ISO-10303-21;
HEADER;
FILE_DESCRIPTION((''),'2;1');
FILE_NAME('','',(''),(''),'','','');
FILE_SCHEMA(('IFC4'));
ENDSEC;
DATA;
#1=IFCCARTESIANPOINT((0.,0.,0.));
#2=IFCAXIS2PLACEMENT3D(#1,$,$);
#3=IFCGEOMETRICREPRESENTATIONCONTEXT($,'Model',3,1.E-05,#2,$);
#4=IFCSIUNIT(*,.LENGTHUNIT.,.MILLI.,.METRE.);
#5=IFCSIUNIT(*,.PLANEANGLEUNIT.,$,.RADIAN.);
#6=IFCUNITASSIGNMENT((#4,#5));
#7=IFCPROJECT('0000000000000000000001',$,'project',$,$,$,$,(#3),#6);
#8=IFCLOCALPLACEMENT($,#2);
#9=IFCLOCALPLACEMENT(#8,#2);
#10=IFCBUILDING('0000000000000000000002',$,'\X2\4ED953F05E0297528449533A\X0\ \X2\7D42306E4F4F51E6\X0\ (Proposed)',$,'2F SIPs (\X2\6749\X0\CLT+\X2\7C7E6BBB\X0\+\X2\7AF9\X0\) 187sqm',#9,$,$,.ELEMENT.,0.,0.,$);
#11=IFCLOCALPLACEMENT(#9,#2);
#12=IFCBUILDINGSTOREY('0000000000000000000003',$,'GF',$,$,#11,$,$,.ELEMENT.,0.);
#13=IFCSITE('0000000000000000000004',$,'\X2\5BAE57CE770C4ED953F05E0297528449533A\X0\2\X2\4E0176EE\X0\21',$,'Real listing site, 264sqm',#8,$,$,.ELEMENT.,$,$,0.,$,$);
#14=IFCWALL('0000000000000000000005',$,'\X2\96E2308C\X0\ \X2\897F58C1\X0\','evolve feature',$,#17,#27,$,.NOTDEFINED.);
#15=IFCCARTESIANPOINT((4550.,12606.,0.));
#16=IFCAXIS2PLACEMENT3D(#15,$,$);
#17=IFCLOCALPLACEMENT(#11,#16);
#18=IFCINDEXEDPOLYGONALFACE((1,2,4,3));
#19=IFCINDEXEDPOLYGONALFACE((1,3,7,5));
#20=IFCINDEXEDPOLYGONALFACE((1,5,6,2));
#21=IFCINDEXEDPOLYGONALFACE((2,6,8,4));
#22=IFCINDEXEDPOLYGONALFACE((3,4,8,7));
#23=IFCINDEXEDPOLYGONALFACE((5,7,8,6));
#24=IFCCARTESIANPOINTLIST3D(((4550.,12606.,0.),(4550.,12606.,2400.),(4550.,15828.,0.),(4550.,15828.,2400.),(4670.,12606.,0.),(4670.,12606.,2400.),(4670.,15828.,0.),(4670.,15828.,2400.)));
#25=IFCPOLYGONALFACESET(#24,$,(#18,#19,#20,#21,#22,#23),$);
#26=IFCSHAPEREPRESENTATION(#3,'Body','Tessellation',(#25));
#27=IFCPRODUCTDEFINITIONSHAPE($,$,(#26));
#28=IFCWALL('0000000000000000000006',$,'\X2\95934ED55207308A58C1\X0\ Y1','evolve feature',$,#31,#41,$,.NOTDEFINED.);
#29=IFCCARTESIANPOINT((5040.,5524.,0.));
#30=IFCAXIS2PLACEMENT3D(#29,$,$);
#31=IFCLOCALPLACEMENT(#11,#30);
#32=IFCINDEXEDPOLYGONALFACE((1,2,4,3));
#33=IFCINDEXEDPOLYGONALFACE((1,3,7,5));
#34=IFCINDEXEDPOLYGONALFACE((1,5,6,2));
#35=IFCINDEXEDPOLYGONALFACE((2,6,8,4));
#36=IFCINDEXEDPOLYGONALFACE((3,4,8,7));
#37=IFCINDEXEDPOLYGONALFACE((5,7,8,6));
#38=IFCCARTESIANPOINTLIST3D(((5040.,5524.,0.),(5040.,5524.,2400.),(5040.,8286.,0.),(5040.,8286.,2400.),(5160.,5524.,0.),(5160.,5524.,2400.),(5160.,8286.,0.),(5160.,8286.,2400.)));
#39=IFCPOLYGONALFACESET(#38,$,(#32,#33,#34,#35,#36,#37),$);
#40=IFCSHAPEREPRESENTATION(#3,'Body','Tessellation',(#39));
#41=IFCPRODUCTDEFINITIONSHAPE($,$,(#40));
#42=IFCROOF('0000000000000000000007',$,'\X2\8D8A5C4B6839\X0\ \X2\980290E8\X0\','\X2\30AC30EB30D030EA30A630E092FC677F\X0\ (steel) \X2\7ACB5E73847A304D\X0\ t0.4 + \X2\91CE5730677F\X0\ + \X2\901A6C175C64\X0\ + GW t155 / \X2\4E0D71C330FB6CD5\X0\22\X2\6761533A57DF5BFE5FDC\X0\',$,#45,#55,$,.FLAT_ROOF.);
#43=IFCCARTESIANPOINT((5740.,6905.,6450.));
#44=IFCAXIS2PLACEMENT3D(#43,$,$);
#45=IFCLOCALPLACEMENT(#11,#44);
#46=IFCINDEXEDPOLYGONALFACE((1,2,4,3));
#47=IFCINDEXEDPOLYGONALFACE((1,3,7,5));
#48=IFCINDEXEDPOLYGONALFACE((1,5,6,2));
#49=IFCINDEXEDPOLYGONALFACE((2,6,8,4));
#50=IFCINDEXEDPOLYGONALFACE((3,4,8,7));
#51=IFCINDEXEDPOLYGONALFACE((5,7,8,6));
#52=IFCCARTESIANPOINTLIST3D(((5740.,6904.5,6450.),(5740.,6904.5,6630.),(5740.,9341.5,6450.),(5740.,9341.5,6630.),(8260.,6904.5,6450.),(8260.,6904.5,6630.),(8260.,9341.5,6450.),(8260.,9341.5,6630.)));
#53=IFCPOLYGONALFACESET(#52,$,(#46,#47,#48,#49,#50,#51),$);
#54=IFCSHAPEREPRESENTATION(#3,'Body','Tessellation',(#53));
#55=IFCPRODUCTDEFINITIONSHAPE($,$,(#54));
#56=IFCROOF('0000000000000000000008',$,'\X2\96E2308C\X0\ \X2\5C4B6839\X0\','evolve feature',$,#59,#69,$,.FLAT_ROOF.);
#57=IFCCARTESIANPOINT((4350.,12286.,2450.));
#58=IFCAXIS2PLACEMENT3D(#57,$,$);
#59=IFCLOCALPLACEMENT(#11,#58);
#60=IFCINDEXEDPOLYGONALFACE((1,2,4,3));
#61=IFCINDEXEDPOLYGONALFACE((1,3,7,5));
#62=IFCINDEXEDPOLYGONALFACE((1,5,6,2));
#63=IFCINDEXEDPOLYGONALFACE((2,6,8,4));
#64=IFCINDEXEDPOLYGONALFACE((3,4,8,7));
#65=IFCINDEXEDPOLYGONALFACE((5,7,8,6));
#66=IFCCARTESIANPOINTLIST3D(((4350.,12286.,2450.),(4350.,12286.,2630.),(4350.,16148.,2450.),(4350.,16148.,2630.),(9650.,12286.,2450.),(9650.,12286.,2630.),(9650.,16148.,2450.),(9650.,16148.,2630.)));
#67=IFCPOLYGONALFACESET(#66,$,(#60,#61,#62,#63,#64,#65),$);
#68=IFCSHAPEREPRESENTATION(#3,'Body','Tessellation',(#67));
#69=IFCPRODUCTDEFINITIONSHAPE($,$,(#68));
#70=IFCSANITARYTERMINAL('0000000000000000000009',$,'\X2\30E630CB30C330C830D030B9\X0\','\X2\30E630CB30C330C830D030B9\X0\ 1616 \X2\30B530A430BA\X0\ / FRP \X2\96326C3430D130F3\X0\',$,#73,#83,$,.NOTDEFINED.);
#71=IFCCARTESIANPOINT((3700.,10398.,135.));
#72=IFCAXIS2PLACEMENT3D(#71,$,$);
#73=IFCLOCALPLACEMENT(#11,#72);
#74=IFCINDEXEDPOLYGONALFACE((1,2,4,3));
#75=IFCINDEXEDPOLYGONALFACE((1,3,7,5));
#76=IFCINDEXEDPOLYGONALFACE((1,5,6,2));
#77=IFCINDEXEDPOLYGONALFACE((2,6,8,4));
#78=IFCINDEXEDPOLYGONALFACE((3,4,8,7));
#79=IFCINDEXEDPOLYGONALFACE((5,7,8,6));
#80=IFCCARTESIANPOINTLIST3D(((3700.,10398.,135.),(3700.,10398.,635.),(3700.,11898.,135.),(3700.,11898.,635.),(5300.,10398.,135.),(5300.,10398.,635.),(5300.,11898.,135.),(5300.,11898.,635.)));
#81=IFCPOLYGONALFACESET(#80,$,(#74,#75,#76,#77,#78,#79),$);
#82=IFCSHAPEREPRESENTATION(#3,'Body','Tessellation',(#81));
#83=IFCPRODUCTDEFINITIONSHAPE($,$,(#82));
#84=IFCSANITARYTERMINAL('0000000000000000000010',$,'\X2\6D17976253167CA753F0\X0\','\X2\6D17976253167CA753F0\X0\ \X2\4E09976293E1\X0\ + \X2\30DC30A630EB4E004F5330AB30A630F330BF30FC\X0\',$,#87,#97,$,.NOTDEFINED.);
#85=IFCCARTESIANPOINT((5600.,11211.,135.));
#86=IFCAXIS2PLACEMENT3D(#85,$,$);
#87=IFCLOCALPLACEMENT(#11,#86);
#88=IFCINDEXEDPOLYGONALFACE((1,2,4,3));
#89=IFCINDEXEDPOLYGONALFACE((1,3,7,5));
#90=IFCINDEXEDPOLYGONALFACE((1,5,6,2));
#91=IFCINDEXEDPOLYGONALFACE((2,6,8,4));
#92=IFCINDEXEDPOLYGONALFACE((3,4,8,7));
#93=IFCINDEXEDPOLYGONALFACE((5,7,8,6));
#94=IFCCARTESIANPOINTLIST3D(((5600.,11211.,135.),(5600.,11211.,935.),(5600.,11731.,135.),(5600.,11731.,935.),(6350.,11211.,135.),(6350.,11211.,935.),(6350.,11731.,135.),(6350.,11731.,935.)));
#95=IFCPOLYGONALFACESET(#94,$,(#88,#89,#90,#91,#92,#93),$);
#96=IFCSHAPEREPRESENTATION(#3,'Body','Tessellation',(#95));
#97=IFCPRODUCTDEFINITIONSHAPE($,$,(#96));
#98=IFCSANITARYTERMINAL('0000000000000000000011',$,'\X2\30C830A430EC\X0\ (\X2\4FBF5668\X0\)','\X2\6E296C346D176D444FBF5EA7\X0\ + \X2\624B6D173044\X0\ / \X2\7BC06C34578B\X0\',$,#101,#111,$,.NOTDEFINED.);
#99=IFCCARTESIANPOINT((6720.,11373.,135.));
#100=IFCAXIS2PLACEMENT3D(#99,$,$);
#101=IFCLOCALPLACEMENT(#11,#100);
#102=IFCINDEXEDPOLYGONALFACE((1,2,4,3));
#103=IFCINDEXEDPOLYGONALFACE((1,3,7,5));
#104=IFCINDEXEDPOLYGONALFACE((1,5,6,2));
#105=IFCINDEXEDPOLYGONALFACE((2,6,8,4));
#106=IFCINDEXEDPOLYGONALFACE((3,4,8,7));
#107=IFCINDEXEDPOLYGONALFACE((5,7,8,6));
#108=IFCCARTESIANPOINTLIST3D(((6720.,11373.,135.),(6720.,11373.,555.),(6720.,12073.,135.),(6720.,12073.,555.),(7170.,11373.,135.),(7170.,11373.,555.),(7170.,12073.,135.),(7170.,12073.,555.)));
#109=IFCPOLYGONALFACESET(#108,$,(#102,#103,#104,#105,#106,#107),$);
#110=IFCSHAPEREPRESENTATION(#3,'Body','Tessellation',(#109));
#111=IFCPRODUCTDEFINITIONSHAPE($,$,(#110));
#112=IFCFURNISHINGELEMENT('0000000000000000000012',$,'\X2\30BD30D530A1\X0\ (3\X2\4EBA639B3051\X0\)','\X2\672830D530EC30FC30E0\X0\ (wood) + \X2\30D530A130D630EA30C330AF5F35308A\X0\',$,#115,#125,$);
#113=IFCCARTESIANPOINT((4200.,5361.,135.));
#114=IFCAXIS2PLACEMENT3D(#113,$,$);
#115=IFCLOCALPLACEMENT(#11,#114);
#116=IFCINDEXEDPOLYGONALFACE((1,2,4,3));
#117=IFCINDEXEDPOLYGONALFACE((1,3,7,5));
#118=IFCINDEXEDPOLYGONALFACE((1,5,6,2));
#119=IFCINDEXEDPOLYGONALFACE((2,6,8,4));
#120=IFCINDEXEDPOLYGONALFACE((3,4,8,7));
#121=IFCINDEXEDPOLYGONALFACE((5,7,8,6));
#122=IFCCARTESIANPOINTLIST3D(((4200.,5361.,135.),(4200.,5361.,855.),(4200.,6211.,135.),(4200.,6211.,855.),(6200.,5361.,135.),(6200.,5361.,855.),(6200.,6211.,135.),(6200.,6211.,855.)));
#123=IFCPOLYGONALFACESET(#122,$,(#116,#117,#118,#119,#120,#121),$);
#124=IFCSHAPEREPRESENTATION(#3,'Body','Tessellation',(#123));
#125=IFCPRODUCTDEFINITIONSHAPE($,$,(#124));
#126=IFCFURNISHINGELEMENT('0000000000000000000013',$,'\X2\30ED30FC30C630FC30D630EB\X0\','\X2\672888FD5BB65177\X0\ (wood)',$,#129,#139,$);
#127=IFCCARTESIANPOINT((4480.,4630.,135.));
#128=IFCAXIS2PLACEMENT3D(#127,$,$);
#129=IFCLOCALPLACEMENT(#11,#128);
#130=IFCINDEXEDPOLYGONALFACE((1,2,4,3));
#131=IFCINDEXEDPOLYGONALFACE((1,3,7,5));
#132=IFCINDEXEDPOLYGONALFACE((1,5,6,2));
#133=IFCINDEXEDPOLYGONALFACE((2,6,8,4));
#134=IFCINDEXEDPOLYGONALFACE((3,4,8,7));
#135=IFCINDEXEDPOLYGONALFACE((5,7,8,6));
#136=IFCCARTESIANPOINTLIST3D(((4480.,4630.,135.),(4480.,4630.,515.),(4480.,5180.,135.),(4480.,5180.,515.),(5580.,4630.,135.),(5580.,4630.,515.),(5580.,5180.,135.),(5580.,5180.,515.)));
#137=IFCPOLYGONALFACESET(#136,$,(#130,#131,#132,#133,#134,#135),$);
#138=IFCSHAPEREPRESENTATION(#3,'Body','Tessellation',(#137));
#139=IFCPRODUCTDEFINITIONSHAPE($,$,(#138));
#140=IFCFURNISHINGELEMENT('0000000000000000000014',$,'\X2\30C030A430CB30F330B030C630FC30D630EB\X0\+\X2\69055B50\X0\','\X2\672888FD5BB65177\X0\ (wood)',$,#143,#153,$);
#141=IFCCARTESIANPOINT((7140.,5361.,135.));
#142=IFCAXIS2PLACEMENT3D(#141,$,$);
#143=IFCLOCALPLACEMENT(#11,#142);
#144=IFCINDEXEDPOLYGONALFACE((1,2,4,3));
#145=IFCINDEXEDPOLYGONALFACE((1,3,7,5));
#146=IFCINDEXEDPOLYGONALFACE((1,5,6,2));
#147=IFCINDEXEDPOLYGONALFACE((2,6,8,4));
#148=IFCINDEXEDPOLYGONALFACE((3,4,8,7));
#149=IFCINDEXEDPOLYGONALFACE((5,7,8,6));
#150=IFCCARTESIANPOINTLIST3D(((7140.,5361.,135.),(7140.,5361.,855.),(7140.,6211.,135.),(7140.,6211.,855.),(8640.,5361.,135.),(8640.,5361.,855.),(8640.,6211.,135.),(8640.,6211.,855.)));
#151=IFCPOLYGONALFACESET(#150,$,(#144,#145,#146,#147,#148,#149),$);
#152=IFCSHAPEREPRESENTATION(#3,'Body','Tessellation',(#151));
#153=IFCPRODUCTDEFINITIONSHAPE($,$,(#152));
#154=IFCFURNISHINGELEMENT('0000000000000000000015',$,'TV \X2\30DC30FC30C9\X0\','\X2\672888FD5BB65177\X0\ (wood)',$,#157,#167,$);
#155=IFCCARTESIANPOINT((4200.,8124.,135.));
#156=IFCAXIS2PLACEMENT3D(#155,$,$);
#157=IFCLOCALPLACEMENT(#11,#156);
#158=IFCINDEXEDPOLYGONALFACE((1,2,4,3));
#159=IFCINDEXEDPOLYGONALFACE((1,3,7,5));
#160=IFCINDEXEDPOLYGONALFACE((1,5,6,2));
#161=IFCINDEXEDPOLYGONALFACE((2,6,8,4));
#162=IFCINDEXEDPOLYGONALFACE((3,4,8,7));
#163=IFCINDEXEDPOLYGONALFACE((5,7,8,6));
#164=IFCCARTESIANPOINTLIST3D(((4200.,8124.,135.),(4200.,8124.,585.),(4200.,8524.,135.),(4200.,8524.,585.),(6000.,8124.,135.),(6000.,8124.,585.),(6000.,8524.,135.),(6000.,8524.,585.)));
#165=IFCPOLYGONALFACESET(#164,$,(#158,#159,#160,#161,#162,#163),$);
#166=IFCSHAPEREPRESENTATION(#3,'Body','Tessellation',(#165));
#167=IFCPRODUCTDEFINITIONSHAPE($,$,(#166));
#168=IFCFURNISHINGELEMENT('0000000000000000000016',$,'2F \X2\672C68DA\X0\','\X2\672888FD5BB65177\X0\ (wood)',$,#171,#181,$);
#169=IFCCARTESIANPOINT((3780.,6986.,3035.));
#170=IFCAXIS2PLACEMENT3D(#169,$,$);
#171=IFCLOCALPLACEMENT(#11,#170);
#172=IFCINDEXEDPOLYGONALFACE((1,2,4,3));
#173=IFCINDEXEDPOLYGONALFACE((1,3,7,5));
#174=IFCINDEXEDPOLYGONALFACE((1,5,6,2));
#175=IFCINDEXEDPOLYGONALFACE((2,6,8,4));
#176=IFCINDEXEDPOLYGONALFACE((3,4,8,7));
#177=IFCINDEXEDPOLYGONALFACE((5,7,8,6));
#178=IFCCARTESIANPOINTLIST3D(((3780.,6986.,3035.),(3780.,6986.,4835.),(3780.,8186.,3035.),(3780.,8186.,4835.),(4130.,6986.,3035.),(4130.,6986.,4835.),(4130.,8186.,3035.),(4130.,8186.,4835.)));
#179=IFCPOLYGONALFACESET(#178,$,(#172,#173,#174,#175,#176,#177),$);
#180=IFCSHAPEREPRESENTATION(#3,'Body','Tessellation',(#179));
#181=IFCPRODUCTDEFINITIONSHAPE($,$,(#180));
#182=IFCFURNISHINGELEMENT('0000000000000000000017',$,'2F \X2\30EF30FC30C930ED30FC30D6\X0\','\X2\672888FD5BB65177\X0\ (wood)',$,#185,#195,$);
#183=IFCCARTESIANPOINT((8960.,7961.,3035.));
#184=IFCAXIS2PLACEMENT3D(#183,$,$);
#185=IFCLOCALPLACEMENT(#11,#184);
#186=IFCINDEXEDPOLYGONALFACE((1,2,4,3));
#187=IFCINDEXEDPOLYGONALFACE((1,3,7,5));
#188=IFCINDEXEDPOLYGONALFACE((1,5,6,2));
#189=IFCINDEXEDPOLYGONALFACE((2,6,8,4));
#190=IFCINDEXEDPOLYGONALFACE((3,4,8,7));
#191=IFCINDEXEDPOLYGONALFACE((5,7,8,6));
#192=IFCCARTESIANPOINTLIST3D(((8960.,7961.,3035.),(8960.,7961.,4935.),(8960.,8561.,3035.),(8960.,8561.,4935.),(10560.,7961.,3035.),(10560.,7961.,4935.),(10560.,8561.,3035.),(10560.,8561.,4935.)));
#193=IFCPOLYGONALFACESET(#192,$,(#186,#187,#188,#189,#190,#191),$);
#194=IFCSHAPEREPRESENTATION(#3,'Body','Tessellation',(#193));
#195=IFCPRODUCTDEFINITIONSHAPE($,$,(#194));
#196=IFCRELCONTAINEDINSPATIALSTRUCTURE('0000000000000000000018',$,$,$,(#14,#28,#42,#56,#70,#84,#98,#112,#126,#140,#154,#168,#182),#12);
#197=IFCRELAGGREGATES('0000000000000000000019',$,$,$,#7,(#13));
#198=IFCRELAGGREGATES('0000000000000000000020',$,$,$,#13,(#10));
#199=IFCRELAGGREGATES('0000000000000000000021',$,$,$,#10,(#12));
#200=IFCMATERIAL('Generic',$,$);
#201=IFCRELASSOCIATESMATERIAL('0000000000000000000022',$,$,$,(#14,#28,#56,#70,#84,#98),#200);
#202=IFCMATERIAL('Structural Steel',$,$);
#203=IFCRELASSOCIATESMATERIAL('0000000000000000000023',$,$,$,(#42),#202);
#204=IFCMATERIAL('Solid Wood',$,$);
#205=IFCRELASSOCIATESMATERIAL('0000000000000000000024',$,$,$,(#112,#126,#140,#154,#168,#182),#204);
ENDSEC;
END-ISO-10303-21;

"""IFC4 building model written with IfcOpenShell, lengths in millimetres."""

from ifc_helpers import new_model, si_unit, frame, frame_2d, origin, place, context, project, spatial, rectangle, extrude, material, element, save


model = new_model("IFC4")

# Units and contexts
model_context = context("Model", 3, precision=1e-05, world=origin())
ifc_project = project(units=[si_unit("LENGTHUNIT", "METRE", prefix="MILLI"), si_unit("PLANEANGLEUNIT", "RADIAN")], contexts=[model_context])

# Site, building, storey
site_placement = place(None, origin())
site = spatial("IfcSite", under=ifc_project, at=site_placement, Name="宮城県仙台市青葉区2丁目21", ObjectType="Real listing site, 264sqm", CompositionType="ELEMENT", RefElevation=0.0)
building_placement = place(site_placement, origin())
building = spatial("IfcBuilding", under=site, at=building_placement, Name="仙台市青葉区 終の住処 (Proposed)", ObjectType="2F SIPs (杉CLT+籾殻+竹) 187sqm", CompositionType="ELEMENT", ElevationOfRefHeight=0.0, ElevationOfTerrain=0.0)
storey_placement = place(building_placement, origin())
storey = spatial("IfcBuildingStorey", under=building, at=storey_placement, Name="GF", CompositionType="ELEMENT", Elevation=0.0)

# Shared definitions
ifc_material_1 = material(Name="Generic")

# Shared definitions
ifc_material_2 = material(Name="Solid Wood")

# Walls
wall_1_placement = place(storey_placement, frame((4550.0, 12606.0, 0.0)))
element("IfcWall", 1, at=wall_1_placement, inside=storey, material=ifc_material_1, Name="離れ 西壁", Description="evolve feature", PredefinedType="NOTDEFINED", context=model_context, shape_type="SweptSolid", body=[
    extrude(rectangle(XDim=120.0, YDim=3222.0, at=frame_2d((60.0, 1611.0))), frame((4550.0, 12606.0, 0.0)), (0.0, 0.0, 1.0), 2400.0),
])
wall_2_placement = place(storey_placement, frame((5040.0, 5524.0, 0.0)))
element("IfcWall", 2, at=wall_2_placement, inside=storey, material=ifc_material_1, Name="間仕切り壁 Y1", Description="evolve feature", PredefinedType="NOTDEFINED", context=model_context, shape_type="SweptSolid", body=[
    extrude(rectangle(XDim=120.0, YDim=2762.0, at=frame_2d((60.0, 1381.0))), frame((5040.0, 5524.0, 0.0)), (0.0, 0.0, 1.0), 2400.0),
])

# Roofs
ifc_material_3 = material(Name="Structural Steel")
roof_1_placement = place(storey_placement, frame((5740.0, 6905.0, 6450.0)))
element("IfcRoof", 3, at=roof_1_placement, inside=storey, material=ifc_material_3, Name="越屋根 頂部", Description="ガルバリウム鋼板 (steel) 立平葺き t0.4 + 野地板 + 通気層 + GW t155 / 不燃・法22条区域対応", PredefinedType="FLAT_ROOF", context=model_context, shape_type="SweptSolid", body=[
    extrude(rectangle(XDim=2520.0, YDim=2437.0, at=frame_2d((1260.0, 1218.0))), frame((5740.0, 6905.0, 6450.0)), (0.0, 0.0, 1.0), 180.0),
])
roof_2_placement = place(storey_placement, frame((4350.0, 12286.0, 2450.0)))
element("IfcRoof", 4, at=roof_2_placement, inside=storey, material=ifc_material_1, Name="離れ 屋根", Description="evolve feature", PredefinedType="FLAT_ROOF", context=model_context, shape_type="SweptSolid", body=[
    extrude(rectangle(XDim=5300.0, YDim=3862.0, at=frame_2d((2650.0, 1931.0))), frame((4350.0, 12286.0, 2450.0)), (0.0, 0.0, 1.0), 180.0),
])

# Sanitary terminals
sanitary_terminal_1_placement = place(storey_placement, frame((3700.0, 10398.0, 135.0)))
element("IfcSanitaryTerminal", 5, at=sanitary_terminal_1_placement, inside=storey, material=ifc_material_1, Name="ユニットバス", Description="ユニットバス 1616 サイズ / FRP 防水パン", PredefinedType="NOTDEFINED", context=model_context, shape_type="SweptSolid", body=[
    extrude(rectangle(XDim=1600.0, YDim=1500.0, at=frame_2d((800.0, 750.0))), frame((3700.0, 10398.0, 135.0)), (0.0, 0.0, 1.0), 500.0),
])
sanitary_terminal_2_placement = place(storey_placement, frame((5600.0, 11211.0, 135.0)))
element("IfcSanitaryTerminal", 6, at=sanitary_terminal_2_placement, inside=storey, material=ifc_material_1, Name="洗面化粧台", Description="洗面化粧台 三面鏡 + ボウル一体カウンター", PredefinedType="NOTDEFINED", context=model_context, shape_type="SweptSolid", body=[
    extrude(rectangle(XDim=750.0, YDim=520.0, at=frame_2d((375.0, 260.0))), frame((5600.0, 11211.0, 135.0)), (0.0, 0.0, 1.0), 800.0),
])
sanitary_terminal_3_placement = place(storey_placement, frame((6720.0, 11373.0, 135.0)))
element("IfcSanitaryTerminal", 7, at=sanitary_terminal_3_placement, inside=storey, material=ifc_material_1, Name="トイレ (便器)", Description="温水洗浄便座 + 手洗い / 節水型", PredefinedType="NOTDEFINED", context=model_context, shape_type="SweptSolid", body=[
    extrude(rectangle(XDim=450.0, YDim=700.0, at=frame_2d((225.0, 350.0))), frame((6720.0, 11373.0, 135.0)), (0.0, 0.0, 1.0), 420.0),
])

# Furnishing elements
furnishing_1_placement = place(storey_placement, frame((4200.0, 5361.0, 135.0)))
element("IfcFurnishingElement", 8, at=furnishing_1_placement, inside=storey, material=ifc_material_2, Name="ソファ (3人掛け)", Description="木フレーム (wood) + ファブリック張り", context=model_context, shape_type="SweptSolid", body=[
    extrude(rectangle(XDim=2000.0, YDim=850.0, at=frame_2d((1000.0, 425.0))), frame((4200.0, 5361.0, 135.0)), (0.0, 0.0, 1.0), 720.0),
])
furnishing_2_placement = place(storey_placement, frame((4480.0, 4630.0, 135.0)))
element("IfcFurnishingElement", 9, at=furnishing_2_placement, inside=storey, material=ifc_material_2, Name="ローテーブル", Description="木製家具 (wood)", context=model_context, shape_type="SweptSolid", body=[
    extrude(rectangle(XDim=1100.0, YDim=550.0, at=frame_2d((550.0, 275.0))), frame((4480.0, 4630.0, 135.0)), (0.0, 0.0, 1.0), 380.0),
])
furnishing_3_placement = place(storey_placement, frame((7140.0, 5361.0, 135.0)))
element("IfcFurnishingElement", 10, at=furnishing_3_placement, inside=storey, material=ifc_material_2, Name="ダイニングテーブル+椅子", Description="木製家具 (wood)", context=model_context, shape_type="SweptSolid", body=[
    extrude(rectangle(XDim=1500.0, YDim=850.0, at=frame_2d((750.0, 425.0))), frame((7140.0, 5361.0, 135.0)), (0.0, 0.0, 1.0), 720.0),
])
furnishing_4_placement = place(storey_placement, frame((4200.0, 8124.0, 135.0)))
element("IfcFurnishingElement", 11, at=furnishing_4_placement, inside=storey, material=ifc_material_2, Name="TV ボード", Description="木製家具 (wood)", context=model_context, shape_type="SweptSolid", body=[
    extrude(rectangle(XDim=1800.0, YDim=400.0, at=frame_2d((900.0, 200.0))), frame((4200.0, 8124.0, 135.0)), (0.0, 0.0, 1.0), 450.0),
])
furnishing_5_placement = place(storey_placement, frame((3780.0, 6986.0, 3035.0)))
element("IfcFurnishingElement", 12, at=furnishing_5_placement, inside=storey, material=ifc_material_2, Name="2F 本棚", Description="木製家具 (wood)", context=model_context, shape_type="SweptSolid", body=[
    extrude(rectangle(XDim=350.0, YDim=1200.0, at=frame_2d((175.0, 600.0))), frame((3780.0, 6986.0, 3035.0)), (0.0, 0.0, 1.0), 1800.0),
])
furnishing_6_placement = place(storey_placement, frame((8960.0, 7961.0, 3035.0)))
element("IfcFurnishingElement", 13, at=furnishing_6_placement, inside=storey, material=ifc_material_2, Name="2F ワードローブ", Description="木製家具 (wood)", context=model_context, shape_type="SweptSolid", body=[
    extrude(rectangle(XDim=1600.0, YDim=600.0, at=frame_2d((800.0, 300.0))), frame((8960.0, 7961.0, 3035.0)), (0.0, 0.0, 1.0), 1900.0),
])

save(model, "model.ifc")
